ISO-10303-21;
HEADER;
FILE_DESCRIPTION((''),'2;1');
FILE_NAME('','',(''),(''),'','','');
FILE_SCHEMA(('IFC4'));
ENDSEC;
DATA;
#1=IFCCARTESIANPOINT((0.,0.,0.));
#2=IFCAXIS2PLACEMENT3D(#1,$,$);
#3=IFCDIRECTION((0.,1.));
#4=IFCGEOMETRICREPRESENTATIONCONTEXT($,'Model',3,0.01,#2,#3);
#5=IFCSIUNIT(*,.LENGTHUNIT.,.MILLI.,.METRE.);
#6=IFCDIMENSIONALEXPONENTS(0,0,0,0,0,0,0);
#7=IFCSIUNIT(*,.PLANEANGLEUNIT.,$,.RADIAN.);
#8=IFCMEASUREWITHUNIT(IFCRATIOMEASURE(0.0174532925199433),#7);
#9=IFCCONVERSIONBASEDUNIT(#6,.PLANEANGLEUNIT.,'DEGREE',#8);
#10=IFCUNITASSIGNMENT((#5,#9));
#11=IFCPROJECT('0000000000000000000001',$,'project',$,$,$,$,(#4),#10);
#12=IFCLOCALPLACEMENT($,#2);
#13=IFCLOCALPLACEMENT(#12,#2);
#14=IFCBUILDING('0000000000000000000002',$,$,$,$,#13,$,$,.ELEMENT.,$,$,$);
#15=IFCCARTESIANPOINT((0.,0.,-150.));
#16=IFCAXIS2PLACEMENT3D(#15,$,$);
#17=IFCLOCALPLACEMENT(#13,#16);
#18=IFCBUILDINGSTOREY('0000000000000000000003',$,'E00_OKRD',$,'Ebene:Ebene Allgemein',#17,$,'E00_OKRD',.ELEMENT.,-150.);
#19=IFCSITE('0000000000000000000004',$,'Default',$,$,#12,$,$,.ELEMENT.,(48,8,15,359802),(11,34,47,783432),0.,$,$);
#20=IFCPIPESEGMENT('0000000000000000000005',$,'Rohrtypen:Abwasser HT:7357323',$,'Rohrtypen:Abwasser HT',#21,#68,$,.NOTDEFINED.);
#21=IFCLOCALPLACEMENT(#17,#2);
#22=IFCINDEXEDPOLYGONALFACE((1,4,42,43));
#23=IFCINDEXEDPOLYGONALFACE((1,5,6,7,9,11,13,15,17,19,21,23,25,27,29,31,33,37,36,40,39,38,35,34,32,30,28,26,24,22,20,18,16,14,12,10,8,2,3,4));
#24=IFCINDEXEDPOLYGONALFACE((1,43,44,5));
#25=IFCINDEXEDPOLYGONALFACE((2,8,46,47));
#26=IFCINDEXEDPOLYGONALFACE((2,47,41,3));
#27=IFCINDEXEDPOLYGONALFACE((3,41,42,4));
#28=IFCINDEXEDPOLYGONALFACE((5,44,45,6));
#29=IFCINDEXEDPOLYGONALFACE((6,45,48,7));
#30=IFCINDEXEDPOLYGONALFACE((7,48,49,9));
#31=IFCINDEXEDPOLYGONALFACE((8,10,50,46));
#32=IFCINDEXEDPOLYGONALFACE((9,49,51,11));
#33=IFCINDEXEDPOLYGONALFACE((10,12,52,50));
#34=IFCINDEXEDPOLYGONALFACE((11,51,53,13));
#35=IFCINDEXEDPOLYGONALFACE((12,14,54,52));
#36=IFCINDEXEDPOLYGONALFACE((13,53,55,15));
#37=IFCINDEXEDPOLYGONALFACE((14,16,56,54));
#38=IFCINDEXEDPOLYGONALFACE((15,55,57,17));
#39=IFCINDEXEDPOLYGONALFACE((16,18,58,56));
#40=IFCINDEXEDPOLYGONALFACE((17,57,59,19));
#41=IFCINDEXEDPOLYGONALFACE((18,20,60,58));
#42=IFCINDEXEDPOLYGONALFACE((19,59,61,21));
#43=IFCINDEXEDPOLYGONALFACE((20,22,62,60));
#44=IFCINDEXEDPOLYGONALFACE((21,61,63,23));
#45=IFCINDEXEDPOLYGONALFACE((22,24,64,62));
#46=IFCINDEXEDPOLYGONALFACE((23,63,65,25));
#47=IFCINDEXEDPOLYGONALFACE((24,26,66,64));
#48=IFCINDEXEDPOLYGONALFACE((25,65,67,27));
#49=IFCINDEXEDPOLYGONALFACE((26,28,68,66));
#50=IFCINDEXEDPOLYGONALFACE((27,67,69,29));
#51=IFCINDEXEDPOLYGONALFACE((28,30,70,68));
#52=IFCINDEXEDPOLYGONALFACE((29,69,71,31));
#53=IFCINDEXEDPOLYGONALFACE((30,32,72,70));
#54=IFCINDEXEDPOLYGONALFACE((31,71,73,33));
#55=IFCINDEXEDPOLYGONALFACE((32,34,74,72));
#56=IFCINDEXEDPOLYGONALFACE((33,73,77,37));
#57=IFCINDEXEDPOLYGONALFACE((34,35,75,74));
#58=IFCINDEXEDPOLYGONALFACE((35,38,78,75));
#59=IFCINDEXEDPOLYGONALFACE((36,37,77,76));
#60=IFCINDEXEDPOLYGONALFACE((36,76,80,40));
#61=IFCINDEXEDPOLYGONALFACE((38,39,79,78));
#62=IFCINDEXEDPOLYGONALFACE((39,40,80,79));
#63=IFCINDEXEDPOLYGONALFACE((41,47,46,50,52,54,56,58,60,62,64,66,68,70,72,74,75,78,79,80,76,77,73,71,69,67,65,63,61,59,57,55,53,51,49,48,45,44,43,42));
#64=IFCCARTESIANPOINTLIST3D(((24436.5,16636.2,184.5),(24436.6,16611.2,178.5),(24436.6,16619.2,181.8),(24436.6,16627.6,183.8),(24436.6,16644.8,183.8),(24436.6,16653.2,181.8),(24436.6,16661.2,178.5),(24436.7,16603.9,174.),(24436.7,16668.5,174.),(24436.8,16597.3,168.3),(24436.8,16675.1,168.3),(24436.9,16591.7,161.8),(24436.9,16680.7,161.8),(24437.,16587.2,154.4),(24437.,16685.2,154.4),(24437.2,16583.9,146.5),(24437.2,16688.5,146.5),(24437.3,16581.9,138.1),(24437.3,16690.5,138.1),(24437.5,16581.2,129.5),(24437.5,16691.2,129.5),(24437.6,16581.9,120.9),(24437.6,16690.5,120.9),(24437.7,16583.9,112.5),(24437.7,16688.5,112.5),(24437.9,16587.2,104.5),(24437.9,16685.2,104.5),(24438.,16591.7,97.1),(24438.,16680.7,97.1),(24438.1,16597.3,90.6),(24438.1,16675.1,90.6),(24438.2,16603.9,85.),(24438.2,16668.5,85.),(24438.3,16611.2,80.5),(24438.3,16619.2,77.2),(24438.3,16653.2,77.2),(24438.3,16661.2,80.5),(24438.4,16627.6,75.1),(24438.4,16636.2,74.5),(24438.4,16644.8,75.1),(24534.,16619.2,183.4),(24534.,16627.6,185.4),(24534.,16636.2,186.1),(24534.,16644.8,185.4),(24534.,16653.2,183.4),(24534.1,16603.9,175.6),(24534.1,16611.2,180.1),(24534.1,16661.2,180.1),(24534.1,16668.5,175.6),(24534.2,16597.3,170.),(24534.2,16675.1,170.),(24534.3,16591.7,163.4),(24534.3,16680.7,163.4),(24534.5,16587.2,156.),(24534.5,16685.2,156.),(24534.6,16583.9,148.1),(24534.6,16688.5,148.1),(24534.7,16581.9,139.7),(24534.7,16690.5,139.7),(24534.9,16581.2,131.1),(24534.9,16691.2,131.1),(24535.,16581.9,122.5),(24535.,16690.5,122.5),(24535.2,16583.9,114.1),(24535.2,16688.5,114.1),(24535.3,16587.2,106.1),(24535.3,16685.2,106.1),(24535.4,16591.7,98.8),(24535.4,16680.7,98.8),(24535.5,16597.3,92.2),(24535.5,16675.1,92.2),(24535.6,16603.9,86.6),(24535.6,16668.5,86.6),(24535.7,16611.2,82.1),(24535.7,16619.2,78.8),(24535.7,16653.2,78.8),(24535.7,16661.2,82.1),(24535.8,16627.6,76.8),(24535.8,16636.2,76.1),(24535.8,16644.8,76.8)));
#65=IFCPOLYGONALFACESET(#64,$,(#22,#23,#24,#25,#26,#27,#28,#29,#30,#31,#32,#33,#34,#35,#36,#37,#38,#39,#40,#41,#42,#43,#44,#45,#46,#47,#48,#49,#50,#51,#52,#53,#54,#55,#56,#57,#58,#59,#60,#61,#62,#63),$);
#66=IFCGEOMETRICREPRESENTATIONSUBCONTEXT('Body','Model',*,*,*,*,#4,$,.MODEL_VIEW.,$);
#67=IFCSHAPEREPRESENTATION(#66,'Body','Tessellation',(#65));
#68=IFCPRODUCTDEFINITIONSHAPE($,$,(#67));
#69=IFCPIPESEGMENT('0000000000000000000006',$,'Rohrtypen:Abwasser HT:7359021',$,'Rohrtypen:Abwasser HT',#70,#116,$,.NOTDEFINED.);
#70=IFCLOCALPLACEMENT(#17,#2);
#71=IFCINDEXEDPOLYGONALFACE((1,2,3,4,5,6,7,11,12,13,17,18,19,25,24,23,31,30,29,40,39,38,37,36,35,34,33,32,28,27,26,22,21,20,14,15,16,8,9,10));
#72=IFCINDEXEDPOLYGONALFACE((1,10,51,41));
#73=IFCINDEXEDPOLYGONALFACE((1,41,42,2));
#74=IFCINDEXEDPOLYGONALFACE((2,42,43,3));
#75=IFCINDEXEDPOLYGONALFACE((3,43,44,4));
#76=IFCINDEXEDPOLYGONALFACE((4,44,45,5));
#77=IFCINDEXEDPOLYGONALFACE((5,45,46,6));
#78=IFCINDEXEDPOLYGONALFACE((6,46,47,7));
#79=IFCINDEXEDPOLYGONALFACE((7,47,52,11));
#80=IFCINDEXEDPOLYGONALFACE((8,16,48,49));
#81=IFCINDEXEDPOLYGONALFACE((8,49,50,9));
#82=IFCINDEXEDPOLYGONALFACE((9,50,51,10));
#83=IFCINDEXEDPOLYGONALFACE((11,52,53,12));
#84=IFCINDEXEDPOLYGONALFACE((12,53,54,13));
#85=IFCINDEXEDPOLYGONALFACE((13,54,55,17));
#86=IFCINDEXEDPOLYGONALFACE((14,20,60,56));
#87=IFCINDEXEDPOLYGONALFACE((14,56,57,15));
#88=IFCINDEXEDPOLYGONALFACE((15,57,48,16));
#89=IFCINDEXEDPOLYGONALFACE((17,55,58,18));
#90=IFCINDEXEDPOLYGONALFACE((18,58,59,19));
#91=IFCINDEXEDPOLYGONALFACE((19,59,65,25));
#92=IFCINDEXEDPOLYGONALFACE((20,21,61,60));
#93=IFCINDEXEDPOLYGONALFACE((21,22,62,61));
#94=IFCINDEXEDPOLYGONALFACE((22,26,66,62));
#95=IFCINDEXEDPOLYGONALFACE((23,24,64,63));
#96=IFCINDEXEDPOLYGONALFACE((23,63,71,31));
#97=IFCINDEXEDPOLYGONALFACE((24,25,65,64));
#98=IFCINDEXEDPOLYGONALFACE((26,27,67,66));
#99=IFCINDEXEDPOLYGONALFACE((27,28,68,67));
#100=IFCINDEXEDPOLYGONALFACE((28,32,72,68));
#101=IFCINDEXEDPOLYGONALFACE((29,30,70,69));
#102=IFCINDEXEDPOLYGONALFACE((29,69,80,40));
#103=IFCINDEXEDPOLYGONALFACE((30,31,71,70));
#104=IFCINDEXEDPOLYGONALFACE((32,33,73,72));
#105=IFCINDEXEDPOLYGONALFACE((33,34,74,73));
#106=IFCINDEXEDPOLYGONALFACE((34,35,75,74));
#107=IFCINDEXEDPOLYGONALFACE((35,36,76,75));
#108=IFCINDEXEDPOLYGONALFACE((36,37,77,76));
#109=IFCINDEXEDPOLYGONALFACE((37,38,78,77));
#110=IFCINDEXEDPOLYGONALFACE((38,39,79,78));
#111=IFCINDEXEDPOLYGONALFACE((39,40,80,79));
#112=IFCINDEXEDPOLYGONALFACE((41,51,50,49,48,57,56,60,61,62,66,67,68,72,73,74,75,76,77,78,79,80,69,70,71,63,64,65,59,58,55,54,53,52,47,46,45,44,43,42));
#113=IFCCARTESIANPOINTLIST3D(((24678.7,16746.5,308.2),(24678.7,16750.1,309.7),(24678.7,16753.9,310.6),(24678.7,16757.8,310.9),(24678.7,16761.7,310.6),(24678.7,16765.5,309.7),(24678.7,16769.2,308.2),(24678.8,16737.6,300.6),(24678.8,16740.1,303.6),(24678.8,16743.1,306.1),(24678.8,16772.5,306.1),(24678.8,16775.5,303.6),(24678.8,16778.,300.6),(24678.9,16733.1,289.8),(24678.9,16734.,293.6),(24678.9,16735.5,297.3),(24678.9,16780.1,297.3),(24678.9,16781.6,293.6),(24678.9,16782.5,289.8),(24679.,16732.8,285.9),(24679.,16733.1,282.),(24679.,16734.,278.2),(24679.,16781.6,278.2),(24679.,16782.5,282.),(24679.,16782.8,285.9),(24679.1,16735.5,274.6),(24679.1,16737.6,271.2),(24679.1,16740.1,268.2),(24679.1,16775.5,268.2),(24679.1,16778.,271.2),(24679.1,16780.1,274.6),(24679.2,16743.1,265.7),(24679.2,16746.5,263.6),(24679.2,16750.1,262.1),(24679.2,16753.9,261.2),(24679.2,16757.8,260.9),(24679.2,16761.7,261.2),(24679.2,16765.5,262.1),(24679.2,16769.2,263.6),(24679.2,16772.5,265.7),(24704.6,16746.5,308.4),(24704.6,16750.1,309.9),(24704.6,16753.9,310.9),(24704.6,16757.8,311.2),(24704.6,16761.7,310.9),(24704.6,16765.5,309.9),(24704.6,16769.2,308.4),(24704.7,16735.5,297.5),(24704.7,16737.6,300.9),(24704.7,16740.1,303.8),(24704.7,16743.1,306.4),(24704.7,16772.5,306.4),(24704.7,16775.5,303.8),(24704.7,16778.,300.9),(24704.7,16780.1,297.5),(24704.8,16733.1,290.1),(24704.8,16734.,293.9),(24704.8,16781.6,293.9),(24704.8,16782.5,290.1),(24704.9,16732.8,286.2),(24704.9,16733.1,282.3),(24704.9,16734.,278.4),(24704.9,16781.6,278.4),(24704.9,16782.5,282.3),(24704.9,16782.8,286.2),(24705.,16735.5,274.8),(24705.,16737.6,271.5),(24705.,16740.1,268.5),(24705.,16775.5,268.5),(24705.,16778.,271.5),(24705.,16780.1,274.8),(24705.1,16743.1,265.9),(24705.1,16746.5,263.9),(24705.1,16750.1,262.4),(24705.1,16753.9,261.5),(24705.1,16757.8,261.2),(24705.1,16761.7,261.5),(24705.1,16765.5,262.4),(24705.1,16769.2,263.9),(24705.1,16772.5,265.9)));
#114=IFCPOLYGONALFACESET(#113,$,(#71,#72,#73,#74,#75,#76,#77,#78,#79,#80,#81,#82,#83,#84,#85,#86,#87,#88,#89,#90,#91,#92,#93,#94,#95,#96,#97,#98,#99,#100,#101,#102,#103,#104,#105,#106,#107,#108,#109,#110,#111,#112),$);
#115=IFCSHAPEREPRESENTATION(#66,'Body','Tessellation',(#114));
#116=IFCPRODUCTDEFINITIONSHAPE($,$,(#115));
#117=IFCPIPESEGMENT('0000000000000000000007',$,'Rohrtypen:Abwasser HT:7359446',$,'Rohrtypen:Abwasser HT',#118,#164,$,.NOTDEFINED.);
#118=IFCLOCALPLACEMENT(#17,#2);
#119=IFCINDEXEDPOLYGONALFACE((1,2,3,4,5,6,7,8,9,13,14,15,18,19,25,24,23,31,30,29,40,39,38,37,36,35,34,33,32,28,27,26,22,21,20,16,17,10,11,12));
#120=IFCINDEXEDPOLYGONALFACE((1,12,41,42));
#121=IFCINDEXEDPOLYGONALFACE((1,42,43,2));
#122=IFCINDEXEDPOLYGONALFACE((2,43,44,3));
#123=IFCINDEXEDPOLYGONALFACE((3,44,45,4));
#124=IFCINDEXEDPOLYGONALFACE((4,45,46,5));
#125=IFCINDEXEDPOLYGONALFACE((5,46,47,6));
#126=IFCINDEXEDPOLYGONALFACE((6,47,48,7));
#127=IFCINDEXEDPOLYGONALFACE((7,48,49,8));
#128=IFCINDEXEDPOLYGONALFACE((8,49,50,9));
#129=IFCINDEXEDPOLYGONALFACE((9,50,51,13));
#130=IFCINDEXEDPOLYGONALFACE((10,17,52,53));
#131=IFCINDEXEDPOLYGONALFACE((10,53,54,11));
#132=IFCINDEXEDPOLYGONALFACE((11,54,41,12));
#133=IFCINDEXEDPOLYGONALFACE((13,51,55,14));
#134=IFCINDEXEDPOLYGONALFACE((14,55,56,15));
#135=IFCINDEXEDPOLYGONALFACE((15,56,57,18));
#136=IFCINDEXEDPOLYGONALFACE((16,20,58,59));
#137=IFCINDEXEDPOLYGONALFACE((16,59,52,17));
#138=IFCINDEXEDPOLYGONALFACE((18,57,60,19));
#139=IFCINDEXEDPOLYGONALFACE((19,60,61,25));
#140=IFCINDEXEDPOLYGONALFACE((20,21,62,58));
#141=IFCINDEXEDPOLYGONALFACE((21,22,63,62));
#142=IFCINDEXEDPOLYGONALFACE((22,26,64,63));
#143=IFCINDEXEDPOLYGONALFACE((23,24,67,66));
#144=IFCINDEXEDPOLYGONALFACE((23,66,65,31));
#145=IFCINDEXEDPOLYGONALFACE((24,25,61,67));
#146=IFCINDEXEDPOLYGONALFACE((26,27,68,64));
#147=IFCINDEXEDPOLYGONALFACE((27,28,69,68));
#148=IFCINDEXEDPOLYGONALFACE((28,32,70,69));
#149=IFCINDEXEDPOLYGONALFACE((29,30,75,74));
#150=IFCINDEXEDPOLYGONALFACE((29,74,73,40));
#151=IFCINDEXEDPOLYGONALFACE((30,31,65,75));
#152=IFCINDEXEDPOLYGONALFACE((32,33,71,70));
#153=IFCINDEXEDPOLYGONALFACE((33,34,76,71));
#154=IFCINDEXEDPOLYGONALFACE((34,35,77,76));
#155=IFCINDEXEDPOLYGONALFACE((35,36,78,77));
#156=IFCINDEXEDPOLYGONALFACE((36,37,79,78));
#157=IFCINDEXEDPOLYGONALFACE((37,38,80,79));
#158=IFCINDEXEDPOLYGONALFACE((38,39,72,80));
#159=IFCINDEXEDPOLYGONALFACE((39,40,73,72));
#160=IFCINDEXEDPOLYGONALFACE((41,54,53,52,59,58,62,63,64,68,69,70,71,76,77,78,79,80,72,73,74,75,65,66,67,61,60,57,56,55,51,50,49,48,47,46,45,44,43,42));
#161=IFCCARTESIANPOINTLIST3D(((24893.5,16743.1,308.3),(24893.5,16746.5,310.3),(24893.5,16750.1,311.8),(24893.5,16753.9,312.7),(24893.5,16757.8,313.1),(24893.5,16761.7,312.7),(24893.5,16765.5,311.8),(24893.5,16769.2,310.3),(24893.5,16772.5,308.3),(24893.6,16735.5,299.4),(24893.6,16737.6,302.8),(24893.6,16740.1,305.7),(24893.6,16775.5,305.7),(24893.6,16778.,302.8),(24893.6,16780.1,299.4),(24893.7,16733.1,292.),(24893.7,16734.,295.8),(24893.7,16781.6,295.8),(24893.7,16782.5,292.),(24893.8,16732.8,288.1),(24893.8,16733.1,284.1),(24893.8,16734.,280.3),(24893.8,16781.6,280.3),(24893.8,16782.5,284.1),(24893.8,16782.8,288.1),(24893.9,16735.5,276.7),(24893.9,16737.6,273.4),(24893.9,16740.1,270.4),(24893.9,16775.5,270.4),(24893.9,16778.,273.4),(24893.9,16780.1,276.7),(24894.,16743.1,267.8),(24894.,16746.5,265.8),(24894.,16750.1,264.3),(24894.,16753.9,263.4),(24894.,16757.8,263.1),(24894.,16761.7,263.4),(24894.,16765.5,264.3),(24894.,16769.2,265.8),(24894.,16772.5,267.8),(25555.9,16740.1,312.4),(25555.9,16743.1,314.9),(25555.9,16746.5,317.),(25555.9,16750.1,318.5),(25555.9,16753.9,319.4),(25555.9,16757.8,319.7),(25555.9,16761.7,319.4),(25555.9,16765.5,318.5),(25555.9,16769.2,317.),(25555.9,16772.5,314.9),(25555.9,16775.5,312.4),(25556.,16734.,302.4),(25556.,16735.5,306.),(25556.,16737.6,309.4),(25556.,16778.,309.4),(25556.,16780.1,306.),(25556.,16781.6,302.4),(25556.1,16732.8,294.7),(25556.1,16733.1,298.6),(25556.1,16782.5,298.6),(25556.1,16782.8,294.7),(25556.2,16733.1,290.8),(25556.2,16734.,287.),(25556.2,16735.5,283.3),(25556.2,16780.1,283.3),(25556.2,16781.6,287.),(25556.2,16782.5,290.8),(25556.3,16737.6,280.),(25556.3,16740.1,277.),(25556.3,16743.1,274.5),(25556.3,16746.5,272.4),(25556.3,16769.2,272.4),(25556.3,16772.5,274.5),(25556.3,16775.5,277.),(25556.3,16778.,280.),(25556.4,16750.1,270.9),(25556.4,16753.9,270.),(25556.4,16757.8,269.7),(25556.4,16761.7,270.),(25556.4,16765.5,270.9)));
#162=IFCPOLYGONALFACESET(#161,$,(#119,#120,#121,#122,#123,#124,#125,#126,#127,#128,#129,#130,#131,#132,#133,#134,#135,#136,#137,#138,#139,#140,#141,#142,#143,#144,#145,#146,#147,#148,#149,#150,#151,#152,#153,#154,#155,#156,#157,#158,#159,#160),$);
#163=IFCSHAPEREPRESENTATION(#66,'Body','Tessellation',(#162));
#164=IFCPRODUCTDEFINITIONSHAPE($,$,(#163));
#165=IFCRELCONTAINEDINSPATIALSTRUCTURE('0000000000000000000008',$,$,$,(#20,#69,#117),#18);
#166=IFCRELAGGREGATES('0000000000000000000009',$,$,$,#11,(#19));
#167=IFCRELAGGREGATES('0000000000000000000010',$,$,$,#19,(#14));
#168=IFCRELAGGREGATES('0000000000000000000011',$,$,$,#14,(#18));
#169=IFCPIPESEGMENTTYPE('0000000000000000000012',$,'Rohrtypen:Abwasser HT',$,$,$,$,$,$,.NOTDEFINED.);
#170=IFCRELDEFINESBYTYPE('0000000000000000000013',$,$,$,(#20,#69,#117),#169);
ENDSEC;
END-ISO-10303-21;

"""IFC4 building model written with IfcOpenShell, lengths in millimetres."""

from ifc_helpers import new_model, entity, si_unit, converted_unit, direction, frame, origin, place, context, subcontext, project, spatial, indexed_curve, outline, extrude, type_object, element, save


model = new_model("IFC4")

# Units and contexts
model_context = context("Model", 3, precision=0.01, world=origin(), true_north=direction((0.0, 1.0)))
body_context = subcontext(model_context, "Body", "Model", "MODEL_VIEW")
ifc_project = project(units=[si_unit("LENGTHUNIT", "METRE", prefix="MILLI"), converted_unit("PLANEANGLEUNIT", "DEGREE", entity("IfcRatioMeasure", 0.0174532925199433), si_unit("PLANEANGLEUNIT", "RADIAN"), dimensions=[0, 0, 0, 0, 0, 0, 0])], contexts=[model_context])

# Site, building, storey
site_placement = place(None, origin())
site = spatial("IfcSite", under=ifc_project, at=site_placement, Name="Default", CompositionType="ELEMENT", RefLatitude=(48, 8, 15, 359802), RefLongitude=(11, 34, 47, 783432), RefElevation=0.0)
building_placement = place(site_placement, origin())
building = spatial("IfcBuilding", under=site, at=building_placement, CompositionType="ELEMENT")
storey_placement = place(building_placement, frame((0.0, 0.0, -150.0)))
storey = spatial("IfcBuildingStorey", under=building, at=storey_placement, Name="E00_OKRD", ObjectType="Ebene:Ebene Allgemein", LongName="E00_OKRD", CompositionType="ELEMENT", Elevation=-150.0)

# Pipe segments
pipe_segment_type_1 = type_object("IfcPipeSegmentType", Name="Rohrtypen:Abwasser HT", PredefinedType="NOTDEFINED")
pipe_segment_1_placement = place(storey_placement, origin())
element("IfcPipeSegment", 1, at=pipe_segment_1_placement, inside=storey, type_object=pipe_segment_type_1, Name="Rohrtypen:Abwasser HT:7357323", ObjectType="Rohrtypen:Abwasser HT", PredefinedType="NOTDEFINED", context=body_context, shape_type="SweptSolid", body=[
    extrude(outline(indexed_curve([(55.0, 0.0), (54.3, 8.6), (52.3, 17.0), (49.0, 25.0), (44.5, 32.3), (38.9, 38.9), (32.3, 44.5), (25.0, 49.0), (17.0, 52.3), (8.6, 54.3), (0.0, 55.0), (-8.6, 54.3), (-17.0, 52.3), (-25.0, 49.0), (-32.3, 44.5), (-38.9, 38.9), (-44.5, 32.3), (-49.0, 25.0), (-52.3, 17.0), (-54.3, 8.6), (-55.0, 0.0), (-54.3, -8.6), (-52.3, -17.0), (-49.0, -25.0), (-44.5, -32.3), (-38.9, -38.9), (-32.3, -44.5), (-25.0, -49.0), (-17.0, -52.3), (-8.6, -54.3), (0.0, -55.0), (8.6, -54.3), (17.0, -52.3), (25.0, -49.0), (32.3, -44.5), (38.9, -38.9), (44.5, -32.3), (49.0, -25.0), (52.3, -17.0), (54.3, -8.6), (55.0, 0.0)], self_intersect=False)), frame((24437.5, 16636.2, 129.5), z_axis=(0.999862, 0.0, 0.016604), x_axis=(0.0, -1.0, 0.0)), (0.0, 0.0, 1.0), 97.4),
])
pipe_segment_2_placement = place(storey_placement, origin())
element("IfcPipeSegment", 2, at=pipe_segment_2_placement, inside=storey, type_object=pipe_segment_type_1, Name="Rohrtypen:Abwasser HT:7359021", ObjectType="Rohrtypen:Abwasser HT", PredefinedType="NOTDEFINED", context=body_context, shape_type="SweptSolid", body=[
    extrude(outline(indexed_curve([(25.0, 0.0), (24.7, 3.9), (23.8, 7.7), (22.3, 11.3), (20.2, 14.7), (17.7, 17.7), (14.7, 20.2), (11.3, 22.3), (7.7, 23.8), (3.9, 24.7), (0.0, 25.0), (-3.9, 24.7), (-7.7, 23.8), (-11.3, 22.3), (-14.7, 20.2), (-17.7, 17.7), (-20.2, 14.7), (-22.3, 11.3), (-23.8, 7.7), (-24.7, 3.9), (-25.0, 0.0), (-24.7, -3.9), (-23.8, -7.7), (-22.3, -11.3), (-20.2, -14.7), (-17.7, -17.7), (-14.7, -20.2), (-11.3, -22.3), (-7.7, -23.8), (-3.9, -24.7), (0.0, -25.0), (3.9, -24.7), (7.7, -23.8), (11.3, -22.3), (14.7, -20.2), (17.7, -17.7), (20.2, -14.7), (22.3, -11.3), (23.8, -7.7), (24.7, -3.9), (25.0, 0.0)], self_intersect=False)), frame((24679.0, 16757.8, 285.9), z_axis=(0.99995, 0.0, 0.01), x_axis=(0.0, 1.0, 0.0)), (0.0, 0.0, 1.0), 25.9),
])
pipe_segment_3_placement = place(storey_placement, origin())
element("IfcPipeSegment", 3, at=pipe_segment_3_placement, inside=storey, type_object=pipe_segment_type_1, Name="Rohrtypen:Abwasser HT:7359446", ObjectType="Rohrtypen:Abwasser HT", PredefinedType="NOTDEFINED", context=body_context, shape_type="SweptSolid", body=[
    extrude(outline(indexed_curve([(25.0, 0.0), (24.7, 3.9), (23.8, 7.7), (22.3, 11.3), (20.2, 14.7), (17.7, 17.7), (14.7, 20.2), (11.3, 22.3), (7.7, 23.8), (3.9, 24.7), (0.0, 25.0), (-3.9, 24.7), (-7.7, 23.8), (-11.3, 22.3), (-14.7, 20.2), (-17.7, 17.7), (-20.2, 14.7), (-22.3, 11.3), (-23.8, 7.7), (-24.7, 3.9), (-25.0, 0.0), (-24.7, -3.9), (-23.8, -7.7), (-22.3, -11.3), (-20.2, -14.7), (-17.7, -17.7), (-14.7, -20.2), (-11.3, -22.3), (-7.7, -23.8), (-3.9, -24.7), (0.0, -25.0), (3.9, -24.7), (7.7, -23.8), (11.3, -22.3), (14.7, -20.2), (17.7, -17.7), (20.2, -14.7), (22.3, -11.3), (23.8, -7.7), (24.7, -3.9), (25.0, 0.0)], self_intersect=False)), frame((24893.8, 16757.8, 288.1), z_axis=(0.99995, 0.0, 0.01), x_axis=(0.0, 1.0, 0.0)), (0.0, 0.0, 1.0), 662.4),
])

save(model, "model.ifc")
